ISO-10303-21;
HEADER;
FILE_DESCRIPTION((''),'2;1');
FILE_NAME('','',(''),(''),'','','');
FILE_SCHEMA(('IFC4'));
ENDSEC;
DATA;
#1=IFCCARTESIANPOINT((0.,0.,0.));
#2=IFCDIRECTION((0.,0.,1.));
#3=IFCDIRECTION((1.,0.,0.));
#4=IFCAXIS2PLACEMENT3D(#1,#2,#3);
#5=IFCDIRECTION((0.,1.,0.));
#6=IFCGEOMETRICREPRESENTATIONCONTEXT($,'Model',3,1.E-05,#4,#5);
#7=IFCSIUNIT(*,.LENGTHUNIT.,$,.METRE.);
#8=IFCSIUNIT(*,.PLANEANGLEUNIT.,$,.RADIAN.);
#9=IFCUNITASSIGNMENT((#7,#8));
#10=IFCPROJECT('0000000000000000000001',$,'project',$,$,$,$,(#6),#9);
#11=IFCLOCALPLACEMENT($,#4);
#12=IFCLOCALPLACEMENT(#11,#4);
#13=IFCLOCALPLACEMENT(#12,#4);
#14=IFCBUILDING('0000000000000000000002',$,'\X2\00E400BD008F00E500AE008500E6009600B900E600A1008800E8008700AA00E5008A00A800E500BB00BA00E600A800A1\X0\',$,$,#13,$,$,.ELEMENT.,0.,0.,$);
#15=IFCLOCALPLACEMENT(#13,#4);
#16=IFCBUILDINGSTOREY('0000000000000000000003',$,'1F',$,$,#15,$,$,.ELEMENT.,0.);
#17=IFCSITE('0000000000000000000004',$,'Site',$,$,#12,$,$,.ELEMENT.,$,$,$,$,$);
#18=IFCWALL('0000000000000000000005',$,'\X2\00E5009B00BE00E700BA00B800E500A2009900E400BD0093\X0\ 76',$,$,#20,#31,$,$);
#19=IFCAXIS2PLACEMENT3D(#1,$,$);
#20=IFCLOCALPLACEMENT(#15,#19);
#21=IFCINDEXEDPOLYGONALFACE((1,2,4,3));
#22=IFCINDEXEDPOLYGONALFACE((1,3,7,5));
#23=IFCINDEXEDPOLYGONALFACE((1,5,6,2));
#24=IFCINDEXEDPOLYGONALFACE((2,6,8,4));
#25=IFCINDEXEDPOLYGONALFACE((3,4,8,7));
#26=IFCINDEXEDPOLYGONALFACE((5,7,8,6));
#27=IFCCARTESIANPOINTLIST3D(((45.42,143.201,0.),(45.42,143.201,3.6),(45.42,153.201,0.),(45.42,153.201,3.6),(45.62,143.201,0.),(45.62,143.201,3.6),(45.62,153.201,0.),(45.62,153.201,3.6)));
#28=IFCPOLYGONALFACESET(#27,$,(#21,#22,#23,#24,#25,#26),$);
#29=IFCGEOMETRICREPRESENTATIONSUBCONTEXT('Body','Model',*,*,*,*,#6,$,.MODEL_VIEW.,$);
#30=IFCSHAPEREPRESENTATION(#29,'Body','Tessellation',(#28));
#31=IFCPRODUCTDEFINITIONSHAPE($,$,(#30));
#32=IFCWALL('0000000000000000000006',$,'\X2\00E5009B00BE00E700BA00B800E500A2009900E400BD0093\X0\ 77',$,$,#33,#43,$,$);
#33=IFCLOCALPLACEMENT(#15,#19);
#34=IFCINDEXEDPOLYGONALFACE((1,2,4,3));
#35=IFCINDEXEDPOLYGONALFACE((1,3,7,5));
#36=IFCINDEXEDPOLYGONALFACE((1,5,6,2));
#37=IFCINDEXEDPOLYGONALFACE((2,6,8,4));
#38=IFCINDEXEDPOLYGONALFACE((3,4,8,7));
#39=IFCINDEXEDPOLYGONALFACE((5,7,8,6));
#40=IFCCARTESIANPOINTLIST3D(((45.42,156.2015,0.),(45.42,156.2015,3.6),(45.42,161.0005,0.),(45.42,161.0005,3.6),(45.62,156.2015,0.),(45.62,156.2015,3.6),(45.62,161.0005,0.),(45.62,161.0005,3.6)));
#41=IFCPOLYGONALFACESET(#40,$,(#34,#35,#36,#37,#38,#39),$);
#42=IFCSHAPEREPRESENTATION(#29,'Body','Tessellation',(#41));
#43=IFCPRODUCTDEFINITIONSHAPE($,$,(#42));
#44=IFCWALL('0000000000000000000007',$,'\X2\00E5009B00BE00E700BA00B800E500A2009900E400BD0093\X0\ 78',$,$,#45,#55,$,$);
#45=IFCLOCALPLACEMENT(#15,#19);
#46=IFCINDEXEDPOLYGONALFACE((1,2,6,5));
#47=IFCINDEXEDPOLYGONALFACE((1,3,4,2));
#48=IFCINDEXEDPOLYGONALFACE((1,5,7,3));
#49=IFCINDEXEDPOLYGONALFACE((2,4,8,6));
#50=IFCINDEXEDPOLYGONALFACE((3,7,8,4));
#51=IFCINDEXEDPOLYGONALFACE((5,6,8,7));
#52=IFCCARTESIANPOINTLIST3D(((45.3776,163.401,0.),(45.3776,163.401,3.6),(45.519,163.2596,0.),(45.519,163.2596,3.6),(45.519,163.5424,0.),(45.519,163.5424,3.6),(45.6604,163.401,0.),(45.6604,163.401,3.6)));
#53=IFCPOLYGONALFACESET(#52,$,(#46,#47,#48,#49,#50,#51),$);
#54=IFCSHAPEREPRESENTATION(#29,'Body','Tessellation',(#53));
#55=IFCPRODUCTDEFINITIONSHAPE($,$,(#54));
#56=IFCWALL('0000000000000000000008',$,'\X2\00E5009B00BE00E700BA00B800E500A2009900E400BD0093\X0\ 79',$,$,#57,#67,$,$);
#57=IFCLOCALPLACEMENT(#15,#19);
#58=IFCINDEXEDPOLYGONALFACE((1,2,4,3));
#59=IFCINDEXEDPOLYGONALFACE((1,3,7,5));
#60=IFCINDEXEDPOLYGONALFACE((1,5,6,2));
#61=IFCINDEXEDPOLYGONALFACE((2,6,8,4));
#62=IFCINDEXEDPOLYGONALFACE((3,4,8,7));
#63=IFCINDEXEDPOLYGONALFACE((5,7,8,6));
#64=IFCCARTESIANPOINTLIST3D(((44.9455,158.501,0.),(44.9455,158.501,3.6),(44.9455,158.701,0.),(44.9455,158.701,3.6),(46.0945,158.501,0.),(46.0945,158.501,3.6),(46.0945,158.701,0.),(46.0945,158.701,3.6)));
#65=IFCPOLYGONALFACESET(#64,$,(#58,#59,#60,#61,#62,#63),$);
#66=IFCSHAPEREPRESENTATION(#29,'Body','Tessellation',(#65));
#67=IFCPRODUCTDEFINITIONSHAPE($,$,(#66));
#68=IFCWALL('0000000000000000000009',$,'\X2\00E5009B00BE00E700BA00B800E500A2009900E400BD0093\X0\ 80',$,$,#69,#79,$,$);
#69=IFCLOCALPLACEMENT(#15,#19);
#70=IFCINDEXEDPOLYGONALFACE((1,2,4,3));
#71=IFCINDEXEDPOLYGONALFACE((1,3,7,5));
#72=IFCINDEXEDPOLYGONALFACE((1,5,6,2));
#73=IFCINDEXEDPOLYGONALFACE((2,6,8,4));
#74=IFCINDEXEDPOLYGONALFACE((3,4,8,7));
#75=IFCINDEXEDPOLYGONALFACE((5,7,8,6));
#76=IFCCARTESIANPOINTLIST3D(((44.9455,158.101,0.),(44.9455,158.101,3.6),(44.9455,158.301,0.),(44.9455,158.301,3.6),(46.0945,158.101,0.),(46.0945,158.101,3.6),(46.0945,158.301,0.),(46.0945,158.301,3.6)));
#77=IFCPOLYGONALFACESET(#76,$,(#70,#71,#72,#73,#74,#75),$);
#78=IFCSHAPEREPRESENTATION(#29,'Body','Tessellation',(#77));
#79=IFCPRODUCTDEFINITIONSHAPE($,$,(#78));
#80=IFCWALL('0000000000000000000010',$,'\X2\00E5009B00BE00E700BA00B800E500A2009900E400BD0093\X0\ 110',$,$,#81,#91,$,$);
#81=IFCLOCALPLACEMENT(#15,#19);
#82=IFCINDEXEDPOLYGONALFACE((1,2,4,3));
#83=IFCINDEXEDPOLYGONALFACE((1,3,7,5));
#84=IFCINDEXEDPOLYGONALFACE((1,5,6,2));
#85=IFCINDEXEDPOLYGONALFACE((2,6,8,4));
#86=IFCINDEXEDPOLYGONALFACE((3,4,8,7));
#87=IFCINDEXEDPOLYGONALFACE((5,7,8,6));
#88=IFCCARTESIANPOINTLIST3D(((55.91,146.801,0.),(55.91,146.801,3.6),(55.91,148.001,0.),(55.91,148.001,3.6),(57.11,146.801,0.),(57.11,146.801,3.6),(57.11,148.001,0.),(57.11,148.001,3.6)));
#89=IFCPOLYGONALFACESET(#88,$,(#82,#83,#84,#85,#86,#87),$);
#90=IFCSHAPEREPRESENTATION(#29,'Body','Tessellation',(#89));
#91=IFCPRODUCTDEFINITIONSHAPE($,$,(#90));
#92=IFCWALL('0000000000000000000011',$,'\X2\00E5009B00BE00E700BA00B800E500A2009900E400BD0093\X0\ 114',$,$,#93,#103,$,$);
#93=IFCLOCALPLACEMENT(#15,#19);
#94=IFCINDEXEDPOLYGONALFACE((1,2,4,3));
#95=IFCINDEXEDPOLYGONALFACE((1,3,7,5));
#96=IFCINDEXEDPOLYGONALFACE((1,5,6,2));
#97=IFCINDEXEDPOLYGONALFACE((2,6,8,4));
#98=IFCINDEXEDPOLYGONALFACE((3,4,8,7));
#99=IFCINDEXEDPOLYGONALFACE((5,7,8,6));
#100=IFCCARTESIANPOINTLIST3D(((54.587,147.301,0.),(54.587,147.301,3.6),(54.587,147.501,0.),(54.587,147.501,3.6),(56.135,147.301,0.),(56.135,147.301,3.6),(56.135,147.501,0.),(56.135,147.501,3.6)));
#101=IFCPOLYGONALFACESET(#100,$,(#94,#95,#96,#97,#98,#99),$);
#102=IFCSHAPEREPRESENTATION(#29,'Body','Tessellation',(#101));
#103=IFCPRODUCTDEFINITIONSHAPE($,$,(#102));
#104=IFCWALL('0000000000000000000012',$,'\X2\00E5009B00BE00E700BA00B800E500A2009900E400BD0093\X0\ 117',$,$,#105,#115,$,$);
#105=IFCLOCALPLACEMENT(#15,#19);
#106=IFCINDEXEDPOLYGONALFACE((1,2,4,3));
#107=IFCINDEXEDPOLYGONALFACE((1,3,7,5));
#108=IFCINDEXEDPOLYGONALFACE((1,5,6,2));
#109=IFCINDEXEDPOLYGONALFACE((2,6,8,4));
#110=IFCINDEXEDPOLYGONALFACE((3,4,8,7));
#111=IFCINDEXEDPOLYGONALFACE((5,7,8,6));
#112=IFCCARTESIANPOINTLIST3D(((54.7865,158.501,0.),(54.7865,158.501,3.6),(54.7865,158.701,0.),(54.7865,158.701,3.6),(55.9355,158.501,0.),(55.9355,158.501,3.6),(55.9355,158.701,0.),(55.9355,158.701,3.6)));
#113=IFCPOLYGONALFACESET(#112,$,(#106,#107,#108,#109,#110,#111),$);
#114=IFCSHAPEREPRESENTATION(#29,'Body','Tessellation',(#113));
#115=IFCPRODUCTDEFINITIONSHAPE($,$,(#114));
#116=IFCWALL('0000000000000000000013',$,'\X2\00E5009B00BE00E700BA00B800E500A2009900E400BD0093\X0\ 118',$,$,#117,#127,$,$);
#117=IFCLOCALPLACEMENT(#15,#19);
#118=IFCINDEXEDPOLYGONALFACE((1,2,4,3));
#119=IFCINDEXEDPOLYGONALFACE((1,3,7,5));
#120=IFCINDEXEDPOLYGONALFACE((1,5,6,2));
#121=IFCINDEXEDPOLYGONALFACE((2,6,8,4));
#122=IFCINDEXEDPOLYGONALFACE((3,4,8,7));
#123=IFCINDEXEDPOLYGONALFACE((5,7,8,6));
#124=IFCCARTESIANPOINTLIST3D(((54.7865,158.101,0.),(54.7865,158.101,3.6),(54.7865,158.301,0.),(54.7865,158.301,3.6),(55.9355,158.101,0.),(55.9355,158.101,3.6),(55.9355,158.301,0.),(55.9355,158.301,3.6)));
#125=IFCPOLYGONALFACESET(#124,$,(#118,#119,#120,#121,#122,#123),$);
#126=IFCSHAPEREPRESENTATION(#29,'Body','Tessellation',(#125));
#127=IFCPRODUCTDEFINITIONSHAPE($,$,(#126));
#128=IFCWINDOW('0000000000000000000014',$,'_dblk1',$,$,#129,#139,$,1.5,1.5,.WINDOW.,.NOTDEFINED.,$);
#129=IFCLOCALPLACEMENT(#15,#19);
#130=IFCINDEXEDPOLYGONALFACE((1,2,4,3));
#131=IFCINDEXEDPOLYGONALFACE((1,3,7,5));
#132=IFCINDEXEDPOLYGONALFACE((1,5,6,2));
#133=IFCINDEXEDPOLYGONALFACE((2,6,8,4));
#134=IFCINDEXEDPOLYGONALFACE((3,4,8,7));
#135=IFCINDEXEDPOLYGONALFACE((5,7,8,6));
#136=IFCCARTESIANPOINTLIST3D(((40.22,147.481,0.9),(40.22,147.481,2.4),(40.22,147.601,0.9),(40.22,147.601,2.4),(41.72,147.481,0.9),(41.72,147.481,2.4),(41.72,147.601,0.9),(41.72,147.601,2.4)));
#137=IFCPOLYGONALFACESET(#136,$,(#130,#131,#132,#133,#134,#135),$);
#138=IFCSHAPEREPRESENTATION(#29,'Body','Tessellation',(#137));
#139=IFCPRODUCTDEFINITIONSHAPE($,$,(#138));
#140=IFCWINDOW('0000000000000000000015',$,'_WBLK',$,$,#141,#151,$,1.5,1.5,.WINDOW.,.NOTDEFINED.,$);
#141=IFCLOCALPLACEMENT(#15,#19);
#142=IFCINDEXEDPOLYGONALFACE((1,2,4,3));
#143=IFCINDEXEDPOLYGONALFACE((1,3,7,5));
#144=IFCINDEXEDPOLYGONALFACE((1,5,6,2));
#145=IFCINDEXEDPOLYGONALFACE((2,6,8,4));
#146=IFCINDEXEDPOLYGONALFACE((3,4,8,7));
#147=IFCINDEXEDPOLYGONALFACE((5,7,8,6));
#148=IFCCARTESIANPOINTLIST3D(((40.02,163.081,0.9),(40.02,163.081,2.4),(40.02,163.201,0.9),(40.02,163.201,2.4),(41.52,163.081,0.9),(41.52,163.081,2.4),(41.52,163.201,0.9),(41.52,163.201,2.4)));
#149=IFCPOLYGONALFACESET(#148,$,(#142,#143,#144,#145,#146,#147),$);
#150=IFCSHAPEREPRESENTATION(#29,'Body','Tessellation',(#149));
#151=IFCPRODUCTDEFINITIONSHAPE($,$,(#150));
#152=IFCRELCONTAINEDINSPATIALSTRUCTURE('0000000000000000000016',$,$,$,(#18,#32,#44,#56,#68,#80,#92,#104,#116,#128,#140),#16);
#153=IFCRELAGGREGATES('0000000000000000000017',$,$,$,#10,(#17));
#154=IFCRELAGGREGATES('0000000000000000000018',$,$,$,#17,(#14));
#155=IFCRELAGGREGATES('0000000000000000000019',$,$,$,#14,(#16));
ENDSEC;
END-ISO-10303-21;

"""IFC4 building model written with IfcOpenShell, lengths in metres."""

from ifc_helpers import new_model, si_unit, direction, frame, frame_2d, origin_with_axes, place, context, subcontext, project, spatial, rectangle, extrude, element, save


model = new_model("IFC4")

# Units and contexts
model_context = context("Model", 3, precision=1e-05, world=origin_with_axes(), true_north=direction((0.0, 1.0, 0.0)))
body_context = subcontext(model_context, "Body", "Model", "MODEL_VIEW")
ifc_project = project(units=[si_unit("LENGTHUNIT", "METRE"), si_unit("PLANEANGLEUNIT", "RADIAN")], contexts=[model_context])

# Site, building, storey
placement = place(None, origin_with_axes())
site_placement = place(placement, origin_with_axes())
site = spatial("IfcSite", under=ifc_project, at=site_placement, Name="Site", CompositionType="ELEMENT")
building_placement = place(site_placement, origin_with_axes())
building = spatial("IfcBuilding", under=site, at=building_placement, Name="ä½\u008få®\u0085æ\u0096¹æ¡\u0088è\u0087ªå\u008a¨å»ºæ¨¡", CompositionType="ELEMENT", ElevationOfRefHeight=0.0, ElevationOfTerrain=0.0)
storey_placement = place(building_placement, origin_with_axes())
storey = spatial("IfcBuildingStorey", under=building, at=storey_placement, Name="1F", CompositionType="ELEMENT", Elevation=0.0)

# Walls
wall_1_placement = place(storey_placement, frame((45.52, 148.201, 0.0), z_axis=(0.0, 0.0, 1.0), x_axis=(0.0, 1.0, 0.0)))
element("IfcWall", 1, at=wall_1_placement, inside=storey, Name="å\u009b¾çº¸å¢\u0099ä½\u0093 76", context=body_context, shape_type="SweptSolid", body=[
    extrude(rectangle(XDim=10.0, YDim=0.2, at=frame_2d((0.0, 0.0), x_axis=(1.0, 0.0, 0.0))), frame((0.0, 0.0, 0.0), z_axis=(0.0, 0.0, 1.0)), (0.0, 0.0, 1.0), 3.6),
])
wall_2_placement = place(storey_placement, frame((45.52, 158.601, 0.0), z_axis=(0.0, 0.0, 1.0), x_axis=(0.0, 1.0, 0.0)))
element("IfcWall", 2, at=wall_2_placement, inside=storey, Name="å\u009b¾çº¸å¢\u0099ä½\u0093 77", context=body_context, shape_type="SweptSolid", body=[
    extrude(rectangle(XDim=4.799, YDim=0.2, at=frame_2d((0.0, 0.0), x_axis=(1.0, 0.0, 0.0))), frame((0.0, 0.0, 0.0), z_axis=(0.0, 0.0, 1.0)), (0.0, 0.0, 1.0), 3.6),
])
wall_3_placement = place(storey_placement, frame((45.519, 163.401, 0.0), z_axis=(0.0, 0.0, 1.0), x_axis=(0.707107, -0.707107, 0.0)))
element("IfcWall", 3, at=wall_3_placement, inside=storey, Name="å\u009b¾çº¸å¢\u0099ä½\u0093 78", context=body_context, shape_type="SweptSolid", body=[
    extrude(rectangle(XDim=0.2, YDim=0.2, at=frame_2d((0.0, 0.0), x_axis=(1.0, 0.0, 0.0))), frame((0.0, 0.0, 0.0), z_axis=(0.0, 0.0, 1.0)), (0.0, 0.0, 1.0), 3.6),
])
for number, where, z_axis, x_axis, name in (
    (4, (45.52, 158.601, 0.0), (0.0, 0.0, 1.0), (1.0, 0.0, 0.0), "å\u009b¾çº¸å¢\u0099ä½\u0093 79"),
    (5, (45.52, 158.201, 0.0), (0.0, 0.0, 1.0), (1.0, 0.0, 0.0), "å\u009b¾çº¸å¢\u0099ä½\u0093 80"),
):
    element("IfcWall", number, at=place(storey_placement, frame(where, z_axis=z_axis, x_axis=x_axis)), inside=storey, Name=name, context=body_context, shape_type="SweptSolid", body=[
        extrude(rectangle(XDim=1.149, YDim=0.2, at=frame_2d((0.0, 0.0), x_axis=(1.0, 0.0, 0.0))), frame((0.0, 0.0, 0.0), z_axis=(0.0, 0.0, 1.0)), (0.0, 0.0, 1.0), 3.6),
    ])
wall_4_placement = place(storey_placement, frame((56.51, 147.401, 0.0), z_axis=(0.0, 0.0, 1.0), x_axis=(1.0, 0.0, 0.0)))
element("IfcWall", 6, at=wall_4_placement, inside=storey, Name="å\u009b¾çº¸å¢\u0099ä½\u0093 110", context=body_context, shape_type="SweptSolid", body=[
    extrude(rectangle(XDim=1.2, YDim=1.2, at=frame_2d((0.0, 0.0), x_axis=(1.0, 0.0, 0.0))), frame((0.0, 0.0, 0.0), z_axis=(0.0, 0.0, 1.0)), (0.0, 0.0, 1.0), 3.6),
])
wall_5_placement = place(storey_placement, frame((55.361, 147.401, 0.0), z_axis=(0.0, 0.0, 1.0), x_axis=(1.0, 0.0, 0.0)))
element("IfcWall", 7, at=wall_5_placement, inside=storey, Name="å\u009b¾çº¸å¢\u0099ä½\u0093 114", context=body_context, shape_type="SweptSolid", body=[
    extrude(rectangle(XDim=1.548, YDim=0.2, at=frame_2d((0.0, 0.0), x_axis=(1.0, 0.0, 0.0))), frame((0.0, 0.0, 0.0), z_axis=(0.0, 0.0, 1.0)), (0.0, 0.0, 1.0), 3.6),
])
for number, where, z_axis, x_axis, name in (
    (8, (55.361, 158.601, 0.0), (0.0, 0.0, 1.0), (1.0, 0.0, 0.0), "å\u009b¾çº¸å¢\u0099ä½\u0093 117"),
    (9, (55.361, 158.201, 0.0), (0.0, 0.0, 1.0), (1.0, 0.0, 0.0), "å\u009b¾çº¸å¢\u0099ä½\u0093 118"),
):
    element("IfcWall", number, at=place(storey_placement, frame(where, z_axis=z_axis, x_axis=x_axis)), inside=storey, Name=name, context=body_context, shape_type="SweptSolid", body=[
        extrude(rectangle(XDim=1.149, YDim=0.2, at=frame_2d((0.0, 0.0), x_axis=(1.0, 0.0, 0.0))), frame((0.0, 0.0, 0.0), z_axis=(0.0, 0.0, 1.0)), (0.0, 0.0, 1.0), 3.6),
    ])

# Windows
for number, where, z_axis, x_axis, name in (
    (10, (40.97, 147.541, 0.9), (0.0, 0.0, 1.0), (1.0, 0.0, 0.0), "_dblk1"),
    (11, (40.77, 163.141, 0.9), (0.0, 0.0, 1.0), (1.0, 0.0, 0.0), "_WBLK"),
):
    element("IfcWindow", number, at=place(storey_placement, frame(where, z_axis=z_axis, x_axis=x_axis)), inside=storey, Name=name, OverallHeight=1.5, OverallWidth=1.5, PartitioningType="NOTDEFINED", PredefinedType="WINDOW", context=body_context, shape_type="SweptSolid", body=[
        extrude(rectangle(XDim=1.5, YDim=0.12, at=frame_2d((0.0, 0.0), x_axis=(1.0, 0.0, 0.0))), frame((0.0, 0.0, 0.0), z_axis=(0.0, 0.0, 1.0)), (0.0, 0.0, 1.0), 1.5),
    ])

save(model, "model.ifc")
